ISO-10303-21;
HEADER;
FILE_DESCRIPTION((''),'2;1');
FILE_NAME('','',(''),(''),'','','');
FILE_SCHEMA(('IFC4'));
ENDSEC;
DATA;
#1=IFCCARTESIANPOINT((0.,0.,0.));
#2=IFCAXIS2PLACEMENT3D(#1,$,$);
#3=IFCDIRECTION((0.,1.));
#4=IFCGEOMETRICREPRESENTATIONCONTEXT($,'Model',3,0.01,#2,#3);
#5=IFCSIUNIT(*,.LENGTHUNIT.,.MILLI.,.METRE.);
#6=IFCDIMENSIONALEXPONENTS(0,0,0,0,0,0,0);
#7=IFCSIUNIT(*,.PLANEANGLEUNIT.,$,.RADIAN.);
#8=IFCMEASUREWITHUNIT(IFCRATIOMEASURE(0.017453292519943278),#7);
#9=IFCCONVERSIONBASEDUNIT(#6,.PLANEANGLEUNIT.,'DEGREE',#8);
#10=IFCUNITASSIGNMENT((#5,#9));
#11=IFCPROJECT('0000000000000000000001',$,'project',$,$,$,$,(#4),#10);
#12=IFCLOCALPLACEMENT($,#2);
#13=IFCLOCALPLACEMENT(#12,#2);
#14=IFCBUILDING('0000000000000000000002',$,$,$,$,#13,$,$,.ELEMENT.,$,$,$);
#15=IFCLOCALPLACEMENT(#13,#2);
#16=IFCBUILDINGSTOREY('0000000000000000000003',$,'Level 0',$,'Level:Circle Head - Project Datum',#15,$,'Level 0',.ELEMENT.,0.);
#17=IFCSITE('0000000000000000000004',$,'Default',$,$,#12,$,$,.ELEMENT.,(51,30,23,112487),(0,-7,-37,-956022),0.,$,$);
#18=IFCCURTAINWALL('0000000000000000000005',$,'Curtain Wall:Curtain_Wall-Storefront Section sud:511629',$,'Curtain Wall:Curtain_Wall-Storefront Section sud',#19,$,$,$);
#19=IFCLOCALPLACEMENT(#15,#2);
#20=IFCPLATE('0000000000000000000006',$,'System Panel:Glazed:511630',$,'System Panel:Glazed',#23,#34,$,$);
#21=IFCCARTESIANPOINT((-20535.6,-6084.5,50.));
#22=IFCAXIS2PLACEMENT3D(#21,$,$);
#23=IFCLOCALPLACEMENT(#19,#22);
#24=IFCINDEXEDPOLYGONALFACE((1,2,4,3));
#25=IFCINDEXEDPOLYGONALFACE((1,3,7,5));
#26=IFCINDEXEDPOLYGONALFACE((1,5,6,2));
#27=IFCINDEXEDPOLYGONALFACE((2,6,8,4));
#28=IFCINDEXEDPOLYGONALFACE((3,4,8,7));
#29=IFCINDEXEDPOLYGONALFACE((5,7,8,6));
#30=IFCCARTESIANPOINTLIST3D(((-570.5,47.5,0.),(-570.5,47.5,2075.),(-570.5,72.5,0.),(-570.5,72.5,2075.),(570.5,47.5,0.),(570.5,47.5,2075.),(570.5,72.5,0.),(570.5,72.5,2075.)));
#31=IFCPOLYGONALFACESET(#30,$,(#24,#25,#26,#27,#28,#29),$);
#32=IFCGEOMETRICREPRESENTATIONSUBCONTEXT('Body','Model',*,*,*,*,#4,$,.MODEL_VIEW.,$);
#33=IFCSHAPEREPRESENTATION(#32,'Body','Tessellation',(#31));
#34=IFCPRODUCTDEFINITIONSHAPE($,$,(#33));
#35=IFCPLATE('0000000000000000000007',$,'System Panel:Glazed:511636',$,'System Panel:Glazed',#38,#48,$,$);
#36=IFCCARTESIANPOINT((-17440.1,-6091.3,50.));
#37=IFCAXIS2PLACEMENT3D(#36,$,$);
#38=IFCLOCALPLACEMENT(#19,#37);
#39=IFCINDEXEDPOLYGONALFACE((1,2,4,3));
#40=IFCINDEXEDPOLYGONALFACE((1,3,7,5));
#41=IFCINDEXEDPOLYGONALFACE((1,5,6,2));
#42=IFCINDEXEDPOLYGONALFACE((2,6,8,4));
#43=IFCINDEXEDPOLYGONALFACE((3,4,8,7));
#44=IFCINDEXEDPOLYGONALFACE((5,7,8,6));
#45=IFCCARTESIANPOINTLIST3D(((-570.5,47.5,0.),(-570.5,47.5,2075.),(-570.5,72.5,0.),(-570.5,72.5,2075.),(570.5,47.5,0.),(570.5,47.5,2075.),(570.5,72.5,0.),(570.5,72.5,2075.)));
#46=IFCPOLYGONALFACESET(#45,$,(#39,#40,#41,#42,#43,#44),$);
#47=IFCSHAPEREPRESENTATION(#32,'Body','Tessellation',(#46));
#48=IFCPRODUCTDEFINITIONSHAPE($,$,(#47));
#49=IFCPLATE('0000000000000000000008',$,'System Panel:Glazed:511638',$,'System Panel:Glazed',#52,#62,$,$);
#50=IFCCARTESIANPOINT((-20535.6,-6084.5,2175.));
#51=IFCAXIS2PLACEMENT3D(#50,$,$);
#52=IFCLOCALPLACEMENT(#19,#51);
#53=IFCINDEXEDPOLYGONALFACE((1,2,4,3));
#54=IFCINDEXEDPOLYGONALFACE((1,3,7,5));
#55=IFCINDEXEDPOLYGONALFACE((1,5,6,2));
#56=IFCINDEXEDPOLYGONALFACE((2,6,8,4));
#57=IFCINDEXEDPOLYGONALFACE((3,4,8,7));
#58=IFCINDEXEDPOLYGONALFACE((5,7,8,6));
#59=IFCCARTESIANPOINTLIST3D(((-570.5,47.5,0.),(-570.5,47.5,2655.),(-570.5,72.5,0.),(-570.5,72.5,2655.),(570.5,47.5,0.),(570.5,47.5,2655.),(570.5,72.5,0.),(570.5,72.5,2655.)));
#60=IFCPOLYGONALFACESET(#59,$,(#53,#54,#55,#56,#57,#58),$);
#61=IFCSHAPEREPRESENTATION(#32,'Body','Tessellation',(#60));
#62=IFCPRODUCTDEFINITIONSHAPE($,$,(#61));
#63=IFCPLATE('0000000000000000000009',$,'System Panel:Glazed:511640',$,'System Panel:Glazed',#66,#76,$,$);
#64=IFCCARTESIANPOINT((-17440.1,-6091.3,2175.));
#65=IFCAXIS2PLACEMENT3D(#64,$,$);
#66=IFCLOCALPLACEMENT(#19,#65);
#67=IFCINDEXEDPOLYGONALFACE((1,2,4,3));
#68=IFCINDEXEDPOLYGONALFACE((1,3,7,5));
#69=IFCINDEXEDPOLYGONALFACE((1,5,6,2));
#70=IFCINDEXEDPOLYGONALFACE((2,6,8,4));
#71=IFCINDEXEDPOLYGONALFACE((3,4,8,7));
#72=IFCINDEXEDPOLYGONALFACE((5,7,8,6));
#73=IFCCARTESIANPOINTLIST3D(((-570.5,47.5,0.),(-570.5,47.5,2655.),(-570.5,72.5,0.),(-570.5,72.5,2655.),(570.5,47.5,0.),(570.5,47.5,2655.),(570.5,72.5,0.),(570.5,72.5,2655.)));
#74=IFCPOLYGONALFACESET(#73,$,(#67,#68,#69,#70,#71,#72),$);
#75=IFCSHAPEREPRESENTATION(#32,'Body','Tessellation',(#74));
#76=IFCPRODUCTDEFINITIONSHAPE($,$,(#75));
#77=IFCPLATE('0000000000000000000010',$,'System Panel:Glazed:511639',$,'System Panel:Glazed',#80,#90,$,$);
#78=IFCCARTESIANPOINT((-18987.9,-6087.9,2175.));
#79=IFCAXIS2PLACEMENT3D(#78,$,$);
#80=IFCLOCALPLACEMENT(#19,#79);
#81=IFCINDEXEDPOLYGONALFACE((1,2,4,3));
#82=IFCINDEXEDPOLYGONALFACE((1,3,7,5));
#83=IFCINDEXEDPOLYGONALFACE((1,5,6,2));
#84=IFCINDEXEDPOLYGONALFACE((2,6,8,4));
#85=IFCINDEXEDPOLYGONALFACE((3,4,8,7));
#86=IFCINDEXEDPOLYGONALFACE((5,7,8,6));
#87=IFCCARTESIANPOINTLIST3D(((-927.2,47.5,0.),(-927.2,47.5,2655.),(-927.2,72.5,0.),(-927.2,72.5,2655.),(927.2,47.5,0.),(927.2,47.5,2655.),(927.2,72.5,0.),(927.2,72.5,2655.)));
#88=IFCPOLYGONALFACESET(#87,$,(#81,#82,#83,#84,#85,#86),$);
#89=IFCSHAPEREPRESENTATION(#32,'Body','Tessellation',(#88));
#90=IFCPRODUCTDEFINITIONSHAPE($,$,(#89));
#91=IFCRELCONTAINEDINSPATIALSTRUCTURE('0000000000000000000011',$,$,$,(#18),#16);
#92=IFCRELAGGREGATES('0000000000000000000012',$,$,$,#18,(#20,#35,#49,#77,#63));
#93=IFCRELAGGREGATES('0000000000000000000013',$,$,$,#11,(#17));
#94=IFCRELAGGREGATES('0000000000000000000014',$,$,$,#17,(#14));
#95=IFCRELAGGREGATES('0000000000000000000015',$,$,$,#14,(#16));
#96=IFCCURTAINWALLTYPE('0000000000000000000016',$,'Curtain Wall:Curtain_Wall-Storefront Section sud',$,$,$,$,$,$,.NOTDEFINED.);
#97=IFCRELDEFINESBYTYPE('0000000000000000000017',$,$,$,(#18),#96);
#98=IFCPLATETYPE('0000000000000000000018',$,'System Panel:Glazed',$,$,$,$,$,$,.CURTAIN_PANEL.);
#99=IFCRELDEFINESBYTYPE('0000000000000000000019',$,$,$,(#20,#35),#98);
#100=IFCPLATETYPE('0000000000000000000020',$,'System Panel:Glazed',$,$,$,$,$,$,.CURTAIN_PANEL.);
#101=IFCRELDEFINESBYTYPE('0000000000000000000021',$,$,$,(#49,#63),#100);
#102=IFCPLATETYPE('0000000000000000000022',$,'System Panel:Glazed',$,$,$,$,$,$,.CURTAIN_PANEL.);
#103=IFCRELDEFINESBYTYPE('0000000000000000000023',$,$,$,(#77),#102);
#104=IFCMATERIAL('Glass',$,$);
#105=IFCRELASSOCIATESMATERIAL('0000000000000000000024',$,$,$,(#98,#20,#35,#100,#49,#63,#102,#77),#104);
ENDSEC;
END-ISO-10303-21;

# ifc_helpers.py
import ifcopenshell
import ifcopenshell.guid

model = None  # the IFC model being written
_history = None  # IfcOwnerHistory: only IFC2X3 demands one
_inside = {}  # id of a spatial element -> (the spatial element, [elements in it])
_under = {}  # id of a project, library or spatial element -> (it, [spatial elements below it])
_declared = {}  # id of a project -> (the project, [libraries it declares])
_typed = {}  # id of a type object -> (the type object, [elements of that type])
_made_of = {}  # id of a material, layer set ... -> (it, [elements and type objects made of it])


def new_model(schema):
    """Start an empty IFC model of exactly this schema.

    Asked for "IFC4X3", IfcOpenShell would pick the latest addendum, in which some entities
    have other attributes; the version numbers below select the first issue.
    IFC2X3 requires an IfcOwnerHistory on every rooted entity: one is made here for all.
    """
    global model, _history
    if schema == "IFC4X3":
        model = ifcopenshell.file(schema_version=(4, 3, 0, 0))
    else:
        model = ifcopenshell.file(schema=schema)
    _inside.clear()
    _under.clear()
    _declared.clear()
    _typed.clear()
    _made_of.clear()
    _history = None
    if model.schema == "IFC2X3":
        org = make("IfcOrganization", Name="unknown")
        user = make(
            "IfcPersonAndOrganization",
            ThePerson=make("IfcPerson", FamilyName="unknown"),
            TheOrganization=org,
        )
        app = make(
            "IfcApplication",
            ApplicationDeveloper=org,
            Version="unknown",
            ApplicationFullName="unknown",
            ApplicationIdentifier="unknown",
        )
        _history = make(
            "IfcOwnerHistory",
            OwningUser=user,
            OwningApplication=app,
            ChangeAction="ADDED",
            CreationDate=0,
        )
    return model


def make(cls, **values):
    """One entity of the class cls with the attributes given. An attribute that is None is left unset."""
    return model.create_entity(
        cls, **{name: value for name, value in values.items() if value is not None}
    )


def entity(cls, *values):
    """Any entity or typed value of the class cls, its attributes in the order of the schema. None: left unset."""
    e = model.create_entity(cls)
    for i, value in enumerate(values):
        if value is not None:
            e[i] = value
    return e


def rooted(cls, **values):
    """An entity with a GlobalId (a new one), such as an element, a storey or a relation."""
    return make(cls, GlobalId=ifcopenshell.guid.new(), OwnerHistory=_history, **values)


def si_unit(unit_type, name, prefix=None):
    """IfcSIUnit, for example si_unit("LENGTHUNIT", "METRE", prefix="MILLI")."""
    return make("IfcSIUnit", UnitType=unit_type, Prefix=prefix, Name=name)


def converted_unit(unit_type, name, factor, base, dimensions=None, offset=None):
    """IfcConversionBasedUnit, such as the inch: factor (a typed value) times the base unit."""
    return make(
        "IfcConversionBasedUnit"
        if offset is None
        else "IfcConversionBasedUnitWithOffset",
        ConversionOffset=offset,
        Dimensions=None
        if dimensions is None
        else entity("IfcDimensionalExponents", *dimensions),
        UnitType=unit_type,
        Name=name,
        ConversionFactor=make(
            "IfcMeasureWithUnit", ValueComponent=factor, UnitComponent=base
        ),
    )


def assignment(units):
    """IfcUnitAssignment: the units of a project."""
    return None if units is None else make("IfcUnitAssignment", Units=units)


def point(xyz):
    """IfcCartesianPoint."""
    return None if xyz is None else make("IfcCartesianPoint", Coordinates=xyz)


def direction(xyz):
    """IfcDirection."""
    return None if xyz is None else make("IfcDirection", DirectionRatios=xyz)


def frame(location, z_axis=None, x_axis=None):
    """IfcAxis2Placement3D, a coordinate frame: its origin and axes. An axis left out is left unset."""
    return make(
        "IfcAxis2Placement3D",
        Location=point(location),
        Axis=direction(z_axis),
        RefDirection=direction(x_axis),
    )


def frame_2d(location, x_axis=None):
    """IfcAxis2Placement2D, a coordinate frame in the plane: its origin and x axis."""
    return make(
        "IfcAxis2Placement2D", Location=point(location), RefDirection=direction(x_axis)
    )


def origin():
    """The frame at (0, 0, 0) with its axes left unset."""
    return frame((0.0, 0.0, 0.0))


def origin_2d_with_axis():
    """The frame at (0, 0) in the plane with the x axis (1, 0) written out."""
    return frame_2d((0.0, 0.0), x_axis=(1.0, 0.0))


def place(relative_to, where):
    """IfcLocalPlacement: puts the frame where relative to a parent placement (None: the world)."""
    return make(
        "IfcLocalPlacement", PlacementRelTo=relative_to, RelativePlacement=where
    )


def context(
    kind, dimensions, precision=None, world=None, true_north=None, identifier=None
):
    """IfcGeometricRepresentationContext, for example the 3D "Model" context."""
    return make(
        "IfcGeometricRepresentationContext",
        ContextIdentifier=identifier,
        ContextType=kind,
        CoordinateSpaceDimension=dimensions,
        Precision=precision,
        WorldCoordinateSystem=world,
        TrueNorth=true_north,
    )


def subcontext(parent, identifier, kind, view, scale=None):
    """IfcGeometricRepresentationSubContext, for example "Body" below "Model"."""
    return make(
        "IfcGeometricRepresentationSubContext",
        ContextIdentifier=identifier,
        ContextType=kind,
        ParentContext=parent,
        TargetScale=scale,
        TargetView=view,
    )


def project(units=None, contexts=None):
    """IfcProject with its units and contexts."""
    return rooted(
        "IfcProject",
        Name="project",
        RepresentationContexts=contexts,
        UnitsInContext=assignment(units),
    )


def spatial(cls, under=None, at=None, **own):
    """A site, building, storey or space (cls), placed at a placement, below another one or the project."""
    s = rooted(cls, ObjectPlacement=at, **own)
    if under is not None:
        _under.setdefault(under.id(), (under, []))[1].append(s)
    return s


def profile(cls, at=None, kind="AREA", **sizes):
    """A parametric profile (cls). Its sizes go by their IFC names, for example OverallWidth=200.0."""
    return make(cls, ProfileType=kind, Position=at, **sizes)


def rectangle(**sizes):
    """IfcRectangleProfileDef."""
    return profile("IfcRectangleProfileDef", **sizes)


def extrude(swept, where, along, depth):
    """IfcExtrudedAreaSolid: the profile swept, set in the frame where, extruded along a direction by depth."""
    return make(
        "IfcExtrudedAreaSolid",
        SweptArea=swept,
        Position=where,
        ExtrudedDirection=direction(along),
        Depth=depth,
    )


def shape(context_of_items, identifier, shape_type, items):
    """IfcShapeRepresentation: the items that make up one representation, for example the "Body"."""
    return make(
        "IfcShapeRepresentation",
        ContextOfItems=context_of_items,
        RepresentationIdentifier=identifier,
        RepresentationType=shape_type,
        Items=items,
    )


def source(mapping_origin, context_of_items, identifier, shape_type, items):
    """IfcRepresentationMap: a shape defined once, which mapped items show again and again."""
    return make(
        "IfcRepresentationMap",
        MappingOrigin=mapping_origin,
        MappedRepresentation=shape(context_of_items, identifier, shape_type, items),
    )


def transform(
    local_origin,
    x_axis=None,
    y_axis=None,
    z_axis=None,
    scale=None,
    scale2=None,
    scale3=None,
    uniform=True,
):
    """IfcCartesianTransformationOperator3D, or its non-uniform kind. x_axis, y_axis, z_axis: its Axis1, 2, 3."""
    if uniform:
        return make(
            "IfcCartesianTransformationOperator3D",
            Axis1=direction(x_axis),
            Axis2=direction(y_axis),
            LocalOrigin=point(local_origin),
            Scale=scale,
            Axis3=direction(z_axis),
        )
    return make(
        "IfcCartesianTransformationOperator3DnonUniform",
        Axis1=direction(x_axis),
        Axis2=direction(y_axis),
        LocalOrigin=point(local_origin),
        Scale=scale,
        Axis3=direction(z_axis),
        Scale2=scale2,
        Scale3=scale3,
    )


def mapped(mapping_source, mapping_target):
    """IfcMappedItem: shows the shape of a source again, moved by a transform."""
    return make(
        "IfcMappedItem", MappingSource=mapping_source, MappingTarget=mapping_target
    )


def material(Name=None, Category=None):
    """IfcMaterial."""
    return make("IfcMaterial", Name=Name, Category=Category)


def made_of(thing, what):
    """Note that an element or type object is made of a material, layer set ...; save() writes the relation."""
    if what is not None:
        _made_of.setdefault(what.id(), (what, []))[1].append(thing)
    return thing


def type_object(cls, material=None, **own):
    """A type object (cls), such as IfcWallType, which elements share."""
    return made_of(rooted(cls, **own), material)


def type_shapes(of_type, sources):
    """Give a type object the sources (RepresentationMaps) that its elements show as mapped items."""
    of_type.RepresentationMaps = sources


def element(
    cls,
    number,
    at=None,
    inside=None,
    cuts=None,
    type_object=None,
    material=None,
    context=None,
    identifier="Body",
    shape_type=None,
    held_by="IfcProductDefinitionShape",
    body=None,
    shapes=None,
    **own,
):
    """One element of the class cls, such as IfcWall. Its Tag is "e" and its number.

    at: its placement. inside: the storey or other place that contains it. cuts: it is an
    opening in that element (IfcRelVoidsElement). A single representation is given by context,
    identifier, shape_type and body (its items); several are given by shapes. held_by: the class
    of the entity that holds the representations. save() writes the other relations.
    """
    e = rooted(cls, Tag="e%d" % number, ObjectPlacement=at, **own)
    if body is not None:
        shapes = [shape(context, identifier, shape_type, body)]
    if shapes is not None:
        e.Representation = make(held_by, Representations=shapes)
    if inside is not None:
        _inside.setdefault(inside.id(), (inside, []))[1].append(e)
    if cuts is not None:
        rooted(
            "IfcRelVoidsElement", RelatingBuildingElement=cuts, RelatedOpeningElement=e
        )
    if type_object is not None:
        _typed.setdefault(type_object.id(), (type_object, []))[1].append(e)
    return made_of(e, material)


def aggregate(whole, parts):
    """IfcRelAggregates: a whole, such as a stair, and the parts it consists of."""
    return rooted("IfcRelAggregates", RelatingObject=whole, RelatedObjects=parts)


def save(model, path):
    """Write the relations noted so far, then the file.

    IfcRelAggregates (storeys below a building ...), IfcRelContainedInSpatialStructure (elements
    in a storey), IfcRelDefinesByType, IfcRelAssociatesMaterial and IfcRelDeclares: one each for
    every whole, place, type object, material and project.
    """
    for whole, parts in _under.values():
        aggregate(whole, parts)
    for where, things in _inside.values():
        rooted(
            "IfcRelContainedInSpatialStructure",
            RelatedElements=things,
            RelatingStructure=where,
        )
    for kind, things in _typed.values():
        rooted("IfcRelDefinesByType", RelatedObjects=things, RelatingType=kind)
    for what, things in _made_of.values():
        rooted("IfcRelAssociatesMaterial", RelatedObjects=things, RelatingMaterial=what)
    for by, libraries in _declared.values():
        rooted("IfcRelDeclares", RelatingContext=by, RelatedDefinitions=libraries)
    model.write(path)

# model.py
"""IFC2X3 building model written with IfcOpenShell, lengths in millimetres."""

from ifc_helpers import new_model, entity, si_unit, converted_unit, direction, frame, frame_2d, origin, origin_2d_with_axis, place, context, subcontext, project, spatial, rectangle, extrude, source, transform, mapped, material, type_object, type_shapes, element, aggregate, save


model = new_model("IFC2X3")

# Units and contexts
model_context = context("Model", 3, precision=0.01, world=origin(), true_north=direction((0.0, 1.0)))
body_context = subcontext(model_context, "Body", "Model", "MODEL_VIEW")
ifc_project = project(units=[si_unit("LENGTHUNIT", "METRE", prefix="MILLI"), converted_unit("PLANEANGLEUNIT", "DEGREE", entity("IfcRatioMeasure", 0.017453292519943278), si_unit("PLANEANGLEUNIT", "RADIAN"), dimensions=[0, 0, 0, 0, 0, 0, 0])], contexts=[model_context])

# Site, building, storey
site_placement = place(None, origin())
site = spatial("IfcSite", under=ifc_project, at=site_placement, Name="Default", CompositionType="ELEMENT", RefLatitude=(51, 30, 23, 112487), RefLongitude=(0, -7, -37, -956022), RefElevation=0.0)
building_placement = place(site_placement, origin())
building = spatial("IfcBuilding", under=site, at=building_placement, CompositionType="ELEMENT")
storey_placement = place(building_placement, origin())
storey = spatial("IfcBuildingStorey", under=building, at=storey_placement, Name="Level 0", ObjectType="Level:Circle Head - Project Datum", LongName="Level 0", CompositionType="ELEMENT", Elevation=0.0)

# Curtain wall
curtain_wall_type_1 = type_object("IfcCurtainWallType", Name="Curtain Wall:Curtain_Wall-Storefront Section sud", PredefinedType="NOTDEFINED")
curtain_wall_1_placement = place(storey_placement, origin())
curtain_wall_1 = element("IfcCurtainWall", 1, at=curtain_wall_1_placement, inside=storey, type_object=curtain_wall_type_1, Name="Curtain Wall:Curtain_Wall-Storefront Section sud:511629", ObjectType="Curtain Wall:Curtain_Wall-Storefront Section sud")

# Plates
ifc_material_1 = material(Name="Glass")
plate_type_1 = type_object("IfcPlateType", Name="System Panel:Glazed", PredefinedType="CURTAIN_PANEL", material=ifc_material_1)
shared_shape_1 = source(origin(), body_context, "Body", "SweptSolid", [
    extrude(rectangle(XDim=25.0, YDim=1141.0, at=origin_2d_with_axis()), frame((0.0, 60.0, 0.0), z_axis=(0.0, 0.0, 1.0), x_axis=(0.0, 1.0, 0.0)), (0.0, 0.0, 1.0), 2075.0),
])
type_shapes(plate_type_1, [shared_shape_1])
plate_1_placement = place(curtain_wall_1_placement, frame((-20535.6, -6084.5, 50.0)))
plate_1 = element("IfcPlate", 2, at=plate_1_placement, type_object=plate_type_1, material=ifc_material_1, Name="System Panel:Glazed:511630", ObjectType="System Panel:Glazed", context=body_context, shape_type="MappedRepresentation", body=[
    mapped(shared_shape_1, transform((0.0, 0.0, 0.0), scale=1.0)),
])
plate_2_placement = place(curtain_wall_1_placement, frame((-17440.1, -6091.3, 50.0)))
plate_2 = element("IfcPlate", 3, at=plate_2_placement, type_object=plate_type_1, material=ifc_material_1, Name="System Panel:Glazed:511636", ObjectType="System Panel:Glazed", context=body_context, shape_type="MappedRepresentation", body=[
    mapped(shared_shape_1, transform((0.0, 0.0, 0.0), scale=1.0)),
])
plate_type_2 = type_object("IfcPlateType", Name="System Panel:Glazed", PredefinedType="CURTAIN_PANEL", material=ifc_material_1)
shared_shape_2 = source(origin(), body_context, "Body", "SweptSolid", [
    extrude(rectangle(XDim=25.0, YDim=1141.0, at=frame_2d((0.0, 0.0), x_axis=(1.0, 0.0))), frame((0.0, 60.0, 0.0), z_axis=(0.0, 0.0, 1.0), x_axis=(0.0, 1.0, 0.0)), (0.0, 0.0, 1.0), 2655.0),
])
type_shapes(plate_type_2, [shared_shape_2])
plate_3_placement = place(curtain_wall_1_placement, frame((-20535.6, -6084.5, 2175.0)))
plate_3 = element("IfcPlate", 4, at=plate_3_placement, type_object=plate_type_2, material=ifc_material_1, Name="System Panel:Glazed:511638", ObjectType="System Panel:Glazed", context=body_context, shape_type="MappedRepresentation", body=[
    mapped(shared_shape_2, transform((0.0, 0.0, 0.0), scale=1.0)),
])
plate_4_placement = place(curtain_wall_1_placement, frame((-17440.1, -6091.3, 2175.0)))
plate_4 = element("IfcPlate", 5, at=plate_4_placement, type_object=plate_type_2, material=ifc_material_1, Name="System Panel:Glazed:511640", ObjectType="System Panel:Glazed", context=body_context, shape_type="MappedRepresentation", body=[
    mapped(shared_shape_2, transform((0.0, 0.0, 0.0), scale=1.0)),
])
plate_type_3 = type_object("IfcPlateType", Name="System Panel:Glazed", PredefinedType="CURTAIN_PANEL", material=ifc_material_1)
shared_shape_3 = source(origin(), body_context, "Body", "SweptSolid", [
    extrude(rectangle(XDim=25.0, YDim=1854.5, at=frame_2d((0.0, 0.0), x_axis=(1.0, 0.0))), frame((0.0, 60.0, 0.0), z_axis=(0.0, 0.0, 1.0), x_axis=(0.0, 1.0, 0.0)), (0.0, 0.0, 1.0), 2655.0),
])
type_shapes(plate_type_3, [shared_shape_3])
plate_5_placement = place(curtain_wall_1_placement, frame((-18987.9, -6087.9, 2175.0)))
plate_5 = element("IfcPlate", 6, at=plate_5_placement, type_object=plate_type_3, material=ifc_material_1, Name="System Panel:Glazed:511639", ObjectType="System Panel:Glazed", context=body_context, shape_type="MappedRepresentation", body=[
    mapped(shared_shape_3, transform((0.0, 0.0, 0.0), scale=1.0)),
])
aggregate(curtain_wall_1, [plate_1, plate_2, plate_3, plate_5, plate_4])

save(model, "model.ifc")
